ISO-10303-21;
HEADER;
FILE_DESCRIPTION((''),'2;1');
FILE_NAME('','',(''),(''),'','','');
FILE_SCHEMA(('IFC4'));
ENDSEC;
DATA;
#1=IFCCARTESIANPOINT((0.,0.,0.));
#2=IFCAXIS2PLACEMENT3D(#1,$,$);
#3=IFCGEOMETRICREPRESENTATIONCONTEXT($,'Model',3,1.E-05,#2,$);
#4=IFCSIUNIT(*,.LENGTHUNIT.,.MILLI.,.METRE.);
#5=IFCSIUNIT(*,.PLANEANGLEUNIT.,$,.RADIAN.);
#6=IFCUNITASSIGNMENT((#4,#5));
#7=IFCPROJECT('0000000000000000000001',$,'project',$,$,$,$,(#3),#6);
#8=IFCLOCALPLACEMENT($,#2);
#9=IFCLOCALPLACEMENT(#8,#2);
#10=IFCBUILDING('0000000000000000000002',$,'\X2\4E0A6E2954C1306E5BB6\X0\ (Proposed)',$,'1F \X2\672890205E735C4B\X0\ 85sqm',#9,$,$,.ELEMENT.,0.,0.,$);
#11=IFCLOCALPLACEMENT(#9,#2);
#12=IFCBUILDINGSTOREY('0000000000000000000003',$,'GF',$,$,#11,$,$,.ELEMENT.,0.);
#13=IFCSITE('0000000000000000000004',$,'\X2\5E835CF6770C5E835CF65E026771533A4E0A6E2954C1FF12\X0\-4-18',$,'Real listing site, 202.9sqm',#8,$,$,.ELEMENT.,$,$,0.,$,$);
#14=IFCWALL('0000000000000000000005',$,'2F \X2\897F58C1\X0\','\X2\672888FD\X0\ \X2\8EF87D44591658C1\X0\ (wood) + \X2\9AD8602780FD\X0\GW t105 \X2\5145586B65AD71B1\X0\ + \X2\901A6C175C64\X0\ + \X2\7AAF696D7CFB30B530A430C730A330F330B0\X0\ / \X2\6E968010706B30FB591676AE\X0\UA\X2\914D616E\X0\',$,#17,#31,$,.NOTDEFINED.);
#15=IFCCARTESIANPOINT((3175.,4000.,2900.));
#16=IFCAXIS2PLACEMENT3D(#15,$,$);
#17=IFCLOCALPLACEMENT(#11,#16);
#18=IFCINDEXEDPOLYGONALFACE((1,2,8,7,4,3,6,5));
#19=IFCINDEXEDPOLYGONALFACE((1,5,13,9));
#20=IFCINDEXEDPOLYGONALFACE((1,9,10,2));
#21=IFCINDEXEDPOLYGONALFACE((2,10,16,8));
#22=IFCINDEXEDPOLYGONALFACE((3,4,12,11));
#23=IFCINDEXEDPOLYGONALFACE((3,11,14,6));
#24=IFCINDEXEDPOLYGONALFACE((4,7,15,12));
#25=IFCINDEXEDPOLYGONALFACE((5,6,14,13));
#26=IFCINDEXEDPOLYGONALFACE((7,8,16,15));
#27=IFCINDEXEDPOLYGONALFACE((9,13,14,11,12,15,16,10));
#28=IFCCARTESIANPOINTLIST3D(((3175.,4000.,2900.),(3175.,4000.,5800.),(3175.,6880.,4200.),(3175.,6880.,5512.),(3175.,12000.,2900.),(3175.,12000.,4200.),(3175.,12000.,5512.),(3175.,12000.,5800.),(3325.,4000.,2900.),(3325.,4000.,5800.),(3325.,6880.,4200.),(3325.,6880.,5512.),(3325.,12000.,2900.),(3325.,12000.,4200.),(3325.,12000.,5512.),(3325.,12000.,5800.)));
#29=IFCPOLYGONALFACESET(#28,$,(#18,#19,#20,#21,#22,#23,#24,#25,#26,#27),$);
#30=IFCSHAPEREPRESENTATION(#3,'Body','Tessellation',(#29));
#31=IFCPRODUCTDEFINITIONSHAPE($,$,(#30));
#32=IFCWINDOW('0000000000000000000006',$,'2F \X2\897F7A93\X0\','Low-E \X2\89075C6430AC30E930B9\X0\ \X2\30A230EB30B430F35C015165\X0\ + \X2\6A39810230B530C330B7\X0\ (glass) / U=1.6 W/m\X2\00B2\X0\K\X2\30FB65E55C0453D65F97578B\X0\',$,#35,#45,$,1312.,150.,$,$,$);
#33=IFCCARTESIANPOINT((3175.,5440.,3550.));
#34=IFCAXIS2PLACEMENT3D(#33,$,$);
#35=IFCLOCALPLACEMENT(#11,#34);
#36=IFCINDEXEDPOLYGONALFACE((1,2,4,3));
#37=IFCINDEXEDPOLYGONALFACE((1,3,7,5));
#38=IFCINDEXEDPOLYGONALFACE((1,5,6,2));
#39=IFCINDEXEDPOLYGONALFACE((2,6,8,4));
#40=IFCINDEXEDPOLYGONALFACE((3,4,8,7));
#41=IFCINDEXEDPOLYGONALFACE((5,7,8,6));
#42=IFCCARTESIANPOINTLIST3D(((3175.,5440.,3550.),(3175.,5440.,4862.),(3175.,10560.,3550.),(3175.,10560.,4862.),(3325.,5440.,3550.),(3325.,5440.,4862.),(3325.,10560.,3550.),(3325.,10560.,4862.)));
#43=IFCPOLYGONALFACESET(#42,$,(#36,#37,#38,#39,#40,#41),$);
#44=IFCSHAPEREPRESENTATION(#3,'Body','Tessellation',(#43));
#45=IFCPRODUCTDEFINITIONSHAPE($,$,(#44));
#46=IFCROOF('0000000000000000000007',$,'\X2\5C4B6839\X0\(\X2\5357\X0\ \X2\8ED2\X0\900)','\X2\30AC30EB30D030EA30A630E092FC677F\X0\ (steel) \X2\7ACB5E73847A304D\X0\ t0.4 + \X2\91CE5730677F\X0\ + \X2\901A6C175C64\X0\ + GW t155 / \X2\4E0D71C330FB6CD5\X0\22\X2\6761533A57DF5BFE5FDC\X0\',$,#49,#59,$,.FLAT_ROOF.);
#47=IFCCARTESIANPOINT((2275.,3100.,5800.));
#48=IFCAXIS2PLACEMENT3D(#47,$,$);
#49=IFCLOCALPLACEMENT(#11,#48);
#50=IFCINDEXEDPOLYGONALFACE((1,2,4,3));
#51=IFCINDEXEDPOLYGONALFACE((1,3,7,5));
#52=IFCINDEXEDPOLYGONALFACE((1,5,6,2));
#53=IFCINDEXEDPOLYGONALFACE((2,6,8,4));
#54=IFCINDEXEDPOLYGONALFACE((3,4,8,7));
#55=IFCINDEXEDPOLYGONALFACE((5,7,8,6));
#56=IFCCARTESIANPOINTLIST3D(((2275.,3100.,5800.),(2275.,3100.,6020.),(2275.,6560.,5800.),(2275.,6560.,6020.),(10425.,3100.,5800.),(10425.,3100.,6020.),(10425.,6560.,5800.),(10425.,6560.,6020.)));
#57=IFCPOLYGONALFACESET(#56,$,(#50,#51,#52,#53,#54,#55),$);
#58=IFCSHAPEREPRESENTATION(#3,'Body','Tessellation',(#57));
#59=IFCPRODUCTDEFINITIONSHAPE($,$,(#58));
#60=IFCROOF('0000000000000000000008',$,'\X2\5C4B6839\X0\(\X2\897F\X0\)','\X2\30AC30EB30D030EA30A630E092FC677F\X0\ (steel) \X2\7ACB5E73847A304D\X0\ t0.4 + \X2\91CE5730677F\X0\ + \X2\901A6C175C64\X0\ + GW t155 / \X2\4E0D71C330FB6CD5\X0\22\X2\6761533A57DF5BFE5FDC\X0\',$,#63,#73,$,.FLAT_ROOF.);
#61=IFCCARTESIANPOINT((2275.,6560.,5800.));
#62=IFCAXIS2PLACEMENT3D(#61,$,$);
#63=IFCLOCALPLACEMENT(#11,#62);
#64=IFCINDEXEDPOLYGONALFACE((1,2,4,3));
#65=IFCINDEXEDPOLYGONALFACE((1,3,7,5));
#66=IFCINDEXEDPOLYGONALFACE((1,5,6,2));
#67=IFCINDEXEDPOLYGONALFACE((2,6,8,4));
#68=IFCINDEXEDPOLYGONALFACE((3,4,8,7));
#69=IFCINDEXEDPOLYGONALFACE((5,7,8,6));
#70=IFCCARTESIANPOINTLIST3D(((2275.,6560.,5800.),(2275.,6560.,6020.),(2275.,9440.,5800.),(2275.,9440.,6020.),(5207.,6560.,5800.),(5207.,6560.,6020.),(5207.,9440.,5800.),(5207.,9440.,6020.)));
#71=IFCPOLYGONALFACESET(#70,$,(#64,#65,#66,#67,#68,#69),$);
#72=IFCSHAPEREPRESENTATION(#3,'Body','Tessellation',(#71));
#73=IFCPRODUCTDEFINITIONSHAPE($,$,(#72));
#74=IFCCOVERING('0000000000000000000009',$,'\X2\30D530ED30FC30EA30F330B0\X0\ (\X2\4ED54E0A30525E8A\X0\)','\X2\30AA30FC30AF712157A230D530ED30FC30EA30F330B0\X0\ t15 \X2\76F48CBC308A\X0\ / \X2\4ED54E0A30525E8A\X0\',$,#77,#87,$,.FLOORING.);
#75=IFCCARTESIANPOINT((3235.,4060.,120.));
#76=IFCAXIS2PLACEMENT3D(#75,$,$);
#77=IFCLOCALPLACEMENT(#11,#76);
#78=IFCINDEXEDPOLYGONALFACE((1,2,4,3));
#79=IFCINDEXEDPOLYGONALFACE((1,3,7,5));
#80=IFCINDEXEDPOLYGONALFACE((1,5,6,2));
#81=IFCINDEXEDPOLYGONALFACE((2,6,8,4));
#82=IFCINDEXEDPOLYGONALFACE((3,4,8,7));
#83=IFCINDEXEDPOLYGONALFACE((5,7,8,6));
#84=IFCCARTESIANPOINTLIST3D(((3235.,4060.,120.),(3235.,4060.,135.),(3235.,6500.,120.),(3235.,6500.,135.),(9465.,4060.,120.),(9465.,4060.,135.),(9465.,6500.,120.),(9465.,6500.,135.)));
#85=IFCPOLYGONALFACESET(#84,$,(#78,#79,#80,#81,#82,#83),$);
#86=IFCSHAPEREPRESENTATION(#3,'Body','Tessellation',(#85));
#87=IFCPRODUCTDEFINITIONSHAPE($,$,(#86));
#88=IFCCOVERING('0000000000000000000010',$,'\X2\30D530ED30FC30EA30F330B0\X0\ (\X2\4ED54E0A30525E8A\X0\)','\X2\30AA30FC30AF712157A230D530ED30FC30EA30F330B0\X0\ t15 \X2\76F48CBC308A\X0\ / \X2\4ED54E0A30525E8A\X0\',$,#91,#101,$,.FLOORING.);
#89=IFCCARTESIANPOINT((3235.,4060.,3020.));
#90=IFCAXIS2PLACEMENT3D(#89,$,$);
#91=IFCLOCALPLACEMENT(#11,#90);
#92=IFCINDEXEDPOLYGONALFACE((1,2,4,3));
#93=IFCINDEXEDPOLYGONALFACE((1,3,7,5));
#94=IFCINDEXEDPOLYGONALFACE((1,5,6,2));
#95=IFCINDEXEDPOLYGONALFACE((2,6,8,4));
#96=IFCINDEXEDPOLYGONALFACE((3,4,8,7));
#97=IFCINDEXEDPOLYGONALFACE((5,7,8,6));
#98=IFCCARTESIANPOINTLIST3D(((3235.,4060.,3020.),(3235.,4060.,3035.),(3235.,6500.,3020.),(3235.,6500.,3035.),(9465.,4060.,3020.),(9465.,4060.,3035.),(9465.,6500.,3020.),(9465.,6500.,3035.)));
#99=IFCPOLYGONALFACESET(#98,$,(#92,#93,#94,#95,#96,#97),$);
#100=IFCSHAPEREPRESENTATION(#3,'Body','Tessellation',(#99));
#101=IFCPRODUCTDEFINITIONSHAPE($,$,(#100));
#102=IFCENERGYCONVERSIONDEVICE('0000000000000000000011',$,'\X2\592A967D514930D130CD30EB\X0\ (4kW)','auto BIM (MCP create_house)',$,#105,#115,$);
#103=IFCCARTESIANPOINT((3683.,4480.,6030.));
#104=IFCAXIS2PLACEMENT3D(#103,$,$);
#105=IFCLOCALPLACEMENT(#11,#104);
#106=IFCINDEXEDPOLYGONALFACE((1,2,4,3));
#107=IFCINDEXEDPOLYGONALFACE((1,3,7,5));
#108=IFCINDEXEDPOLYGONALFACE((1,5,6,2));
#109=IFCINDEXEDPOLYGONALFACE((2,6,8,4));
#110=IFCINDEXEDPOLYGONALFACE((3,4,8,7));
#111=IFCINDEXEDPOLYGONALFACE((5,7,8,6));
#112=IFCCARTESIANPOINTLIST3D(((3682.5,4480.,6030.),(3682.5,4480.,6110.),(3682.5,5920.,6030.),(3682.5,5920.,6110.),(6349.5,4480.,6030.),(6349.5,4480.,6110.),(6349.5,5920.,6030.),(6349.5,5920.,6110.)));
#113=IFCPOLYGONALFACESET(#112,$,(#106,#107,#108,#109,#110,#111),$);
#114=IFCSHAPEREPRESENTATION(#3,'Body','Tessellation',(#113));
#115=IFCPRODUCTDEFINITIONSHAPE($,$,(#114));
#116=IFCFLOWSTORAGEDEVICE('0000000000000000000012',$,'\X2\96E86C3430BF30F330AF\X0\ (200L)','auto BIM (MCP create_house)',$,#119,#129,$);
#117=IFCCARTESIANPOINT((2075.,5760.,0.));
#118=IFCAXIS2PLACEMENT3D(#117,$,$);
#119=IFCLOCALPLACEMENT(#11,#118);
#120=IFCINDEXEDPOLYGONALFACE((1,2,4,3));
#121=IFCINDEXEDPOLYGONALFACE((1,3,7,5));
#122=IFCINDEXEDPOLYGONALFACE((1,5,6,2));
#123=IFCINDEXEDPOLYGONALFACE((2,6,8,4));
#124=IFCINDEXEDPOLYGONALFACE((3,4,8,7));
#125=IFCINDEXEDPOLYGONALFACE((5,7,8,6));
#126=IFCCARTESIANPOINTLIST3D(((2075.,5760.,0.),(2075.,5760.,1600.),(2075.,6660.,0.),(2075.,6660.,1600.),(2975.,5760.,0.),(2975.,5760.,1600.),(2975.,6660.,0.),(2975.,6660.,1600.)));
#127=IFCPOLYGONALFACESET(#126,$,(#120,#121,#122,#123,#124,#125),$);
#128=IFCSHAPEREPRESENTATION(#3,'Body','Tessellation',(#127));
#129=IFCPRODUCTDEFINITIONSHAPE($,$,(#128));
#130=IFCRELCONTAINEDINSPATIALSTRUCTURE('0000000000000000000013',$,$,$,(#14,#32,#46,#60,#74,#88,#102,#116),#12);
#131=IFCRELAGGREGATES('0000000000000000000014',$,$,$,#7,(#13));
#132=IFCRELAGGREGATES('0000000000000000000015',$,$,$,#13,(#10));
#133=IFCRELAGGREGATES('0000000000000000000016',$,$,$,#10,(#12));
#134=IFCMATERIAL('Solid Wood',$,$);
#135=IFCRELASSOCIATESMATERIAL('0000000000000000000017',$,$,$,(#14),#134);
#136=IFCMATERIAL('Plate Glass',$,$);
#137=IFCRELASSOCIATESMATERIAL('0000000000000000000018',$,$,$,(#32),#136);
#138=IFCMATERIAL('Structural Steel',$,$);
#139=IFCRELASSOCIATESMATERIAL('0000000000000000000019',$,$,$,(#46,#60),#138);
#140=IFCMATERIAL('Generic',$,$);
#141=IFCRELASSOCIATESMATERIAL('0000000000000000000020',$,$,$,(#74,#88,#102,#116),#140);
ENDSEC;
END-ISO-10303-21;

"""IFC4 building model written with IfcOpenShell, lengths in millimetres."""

from ifc_helpers import new_model, si_unit, frame, frame_2d, origin, place, context, project, spatial, rectangle, extrude, material, element, fill, save


model = new_model("IFC4")

# Units and contexts
model_context = context("Model", 3, precision=1e-05, world=origin())
ifc_project = project(units=[si_unit("LENGTHUNIT", "METRE", prefix="MILLI"), si_unit("PLANEANGLEUNIT", "RADIAN")], contexts=[model_context])

# Site, building, storey
site_placement = place(None, origin())
site = spatial("IfcSite", under=ifc_project, at=site_placement, Name="広島県広島市東区上温品２-4-18", ObjectType="Real listing site, 202.9sqm", CompositionType="ELEMENT", RefElevation=0.0)
building_placement = place(site_placement, origin())
building = spatial("IfcBuilding", under=site, at=building_placement, Name="上温品の家 (Proposed)", ObjectType="1F 木造平屋 85sqm", CompositionType="ELEMENT", ElevationOfRefHeight=0.0, ElevationOfTerrain=0.0)
storey_placement = place(building_placement, origin())
storey = spatial("IfcBuildingStorey", under=building, at=storey_placement, Name="GF", CompositionType="ELEMENT", Elevation=0.0)

# Shared definitions
ifc_material_1 = material(Name="Solid Wood")
ifc_material_2 = material(Name="Generic")

# Shared definitions
ifc_material_3 = material(Name="Plate Glass")

# Wall, opening, window
wall_1_placement = place(storey_placement, frame((3175.0, 4000.0, 2900.0)))
wall_1 = element("IfcWall", 1, at=wall_1_placement, inside=storey, material=ifc_material_1, Name="2F 西壁", Description="木製 軸組外壁 (wood) + 高性能GW t105 充填断熱 + 通気層 + 窯業系サイディング / 準耐火・外皮UA配慮", PredefinedType="NOTDEFINED", context=model_context, shape_type="SweptSolid", body=[
    extrude(rectangle(XDim=150.0, YDim=8000.0, at=frame_2d((75.0, 4000.0))), frame((3175.0, 4000.0, 2900.0)), (0.0, 0.0, 1.0), 2900.0),
])
opening_1_placement = place(storey_placement, frame((3175.0, 5440.0, 3550.0)))
opening_1 = element("IfcOpeningElement", 2, at=opening_1_placement, cuts=wall_1, PredefinedType="NOTDEFINED", context=model_context, shape_type="SweptSolid", body=[
    extrude(rectangle(XDim=150.0, YDim=5120.0, at=frame_2d((75.0, 2560.0))), frame((3175.0, 5440.0, 3550.0)), (0.0, 0.0, 1.0), 1312.0),
])
window_1_placement = place(storey_placement, frame((3175.0, 5440.0, 3550.0)))
window_1 = element("IfcWindow", 3, at=window_1_placement, inside=storey, material=ifc_material_3, Name="2F 西窓", Description="Low-E 複層ガラス アルゴン封入 + 樹脂サッシ (glass) / U=1.6 W/m²K・日射取得型", OverallHeight=1312.0, OverallWidth=150.0, context=model_context, shape_type="SweptSolid", body=[
    extrude(rectangle(XDim=150.0, YDim=5120.0, at=frame_2d((75.0, 2560.0))), frame((3175.0, 5440.0, 3550.0)), (0.0, 0.0, 1.0), 1312.0),
])
fill(opening_1, window_1)

# Roofs
ifc_material_4 = material(Name="Structural Steel")
roof_1_placement = place(storey_placement, frame((2275.0, 3100.0, 5800.0)))
element("IfcRoof", 4, at=roof_1_placement, inside=storey, material=ifc_material_4, Name="屋根(南 軒900)", Description="ガルバリウム鋼板 (steel) 立平葺き t0.4 + 野地板 + 通気層 + GW t155 / 不燃・法22条区域対応", PredefinedType="FLAT_ROOF", context=model_context, shape_type="SweptSolid", body=[
    extrude(rectangle(XDim=8150.0, YDim=3460.0, at=frame_2d((4075.0, 1730.0))), frame((2275.0, 3100.0, 5800.0)), (0.0, 0.0, 1.0), 220.0),
])
roof_2_placement = place(storey_placement, frame((2275.0, 6560.0, 5800.0)))
element("IfcRoof", 5, at=roof_2_placement, inside=storey, material=ifc_material_4, Name="屋根(西)", Description="ガルバリウム鋼板 (steel) 立平葺き t0.4 + 野地板 + 通気層 + GW t155 / 不燃・法22条区域対応", PredefinedType="FLAT_ROOF", context=model_context, shape_type="SweptSolid", body=[
    extrude(rectangle(XDim=2932.0, YDim=2880.0, at=frame_2d((1466.0, 1440.0))), frame((2275.0, 6560.0, 5800.0)), (0.0, 0.0, 1.0), 220.0),
])

# Coverings
covering_1_placement = place(storey_placement, frame((3235.0, 4060.0, 120.0)))
element("IfcCovering", 6, at=covering_1_placement, inside=storey, material=ifc_material_2, Name="フローリング (仕上げ床)", Description="オーク無垢フローリング t15 直貼り / 仕上げ床", PredefinedType="FLOORING", context=model_context, shape_type="SweptSolid", body=[
    extrude(rectangle(XDim=6230.0, YDim=2440.0, at=frame_2d((3115.0, 1220.0))), frame((3235.0, 4060.0, 120.0)), (0.0, 0.0, 1.0), 15.0),
])
covering_2_placement = place(storey_placement, frame((3235.0, 4060.0, 3020.0)))
element("IfcCovering", 7, at=covering_2_placement, inside=storey, material=ifc_material_2, Name="フローリング (仕上げ床)", Description="オーク無垢フローリング t15 直貼り / 仕上げ床", PredefinedType="FLOORING", context=model_context, shape_type="SweptSolid", body=[
    extrude(rectangle(XDim=6230.0, YDim=2440.0, at=frame_2d((3115.0, 1220.0))), frame((3235.0, 4060.0, 3020.0)), (0.0, 0.0, 1.0), 15.0),
])

# Energy conversion device
energy_conversion_device_placement = place(storey_placement, frame((3683.0, 4480.0, 6030.0)))
element("IfcEnergyConversionDevice", 8, at=energy_conversion_device_placement, inside=storey, material=ifc_material_2, Name="太陽光パネル (4kW)", Description="auto BIM (MCP create_house)", context=model_context, shape_type="SweptSolid", body=[
    extrude(rectangle(XDim=2667.0, YDim=1440.0, at=frame_2d((1333.0, 720.0))), frame((3683.0, 4480.0, 6030.0)), (0.0, 0.0, 1.0), 80.0),
])

# Flow storage device
flow_storage_device_placement = place(storey_placement, frame((2075.0, 5760.0, 0.0)))
element("IfcFlowStorageDevice", 9, at=flow_storage_device_placement, inside=storey, material=ifc_material_2, Name="雨水タンク (200L)", Description="auto BIM (MCP create_house)", context=model_context, shape_type="SweptSolid", body=[
    extrude(rectangle(XDim=900.0, YDim=900.0, at=frame_2d((450.0, 450.0))), frame((2075.0, 5760.0, 0.0)), (0.0, 0.0, 1.0), 1600.0),
])

save(model, "model.ifc")
